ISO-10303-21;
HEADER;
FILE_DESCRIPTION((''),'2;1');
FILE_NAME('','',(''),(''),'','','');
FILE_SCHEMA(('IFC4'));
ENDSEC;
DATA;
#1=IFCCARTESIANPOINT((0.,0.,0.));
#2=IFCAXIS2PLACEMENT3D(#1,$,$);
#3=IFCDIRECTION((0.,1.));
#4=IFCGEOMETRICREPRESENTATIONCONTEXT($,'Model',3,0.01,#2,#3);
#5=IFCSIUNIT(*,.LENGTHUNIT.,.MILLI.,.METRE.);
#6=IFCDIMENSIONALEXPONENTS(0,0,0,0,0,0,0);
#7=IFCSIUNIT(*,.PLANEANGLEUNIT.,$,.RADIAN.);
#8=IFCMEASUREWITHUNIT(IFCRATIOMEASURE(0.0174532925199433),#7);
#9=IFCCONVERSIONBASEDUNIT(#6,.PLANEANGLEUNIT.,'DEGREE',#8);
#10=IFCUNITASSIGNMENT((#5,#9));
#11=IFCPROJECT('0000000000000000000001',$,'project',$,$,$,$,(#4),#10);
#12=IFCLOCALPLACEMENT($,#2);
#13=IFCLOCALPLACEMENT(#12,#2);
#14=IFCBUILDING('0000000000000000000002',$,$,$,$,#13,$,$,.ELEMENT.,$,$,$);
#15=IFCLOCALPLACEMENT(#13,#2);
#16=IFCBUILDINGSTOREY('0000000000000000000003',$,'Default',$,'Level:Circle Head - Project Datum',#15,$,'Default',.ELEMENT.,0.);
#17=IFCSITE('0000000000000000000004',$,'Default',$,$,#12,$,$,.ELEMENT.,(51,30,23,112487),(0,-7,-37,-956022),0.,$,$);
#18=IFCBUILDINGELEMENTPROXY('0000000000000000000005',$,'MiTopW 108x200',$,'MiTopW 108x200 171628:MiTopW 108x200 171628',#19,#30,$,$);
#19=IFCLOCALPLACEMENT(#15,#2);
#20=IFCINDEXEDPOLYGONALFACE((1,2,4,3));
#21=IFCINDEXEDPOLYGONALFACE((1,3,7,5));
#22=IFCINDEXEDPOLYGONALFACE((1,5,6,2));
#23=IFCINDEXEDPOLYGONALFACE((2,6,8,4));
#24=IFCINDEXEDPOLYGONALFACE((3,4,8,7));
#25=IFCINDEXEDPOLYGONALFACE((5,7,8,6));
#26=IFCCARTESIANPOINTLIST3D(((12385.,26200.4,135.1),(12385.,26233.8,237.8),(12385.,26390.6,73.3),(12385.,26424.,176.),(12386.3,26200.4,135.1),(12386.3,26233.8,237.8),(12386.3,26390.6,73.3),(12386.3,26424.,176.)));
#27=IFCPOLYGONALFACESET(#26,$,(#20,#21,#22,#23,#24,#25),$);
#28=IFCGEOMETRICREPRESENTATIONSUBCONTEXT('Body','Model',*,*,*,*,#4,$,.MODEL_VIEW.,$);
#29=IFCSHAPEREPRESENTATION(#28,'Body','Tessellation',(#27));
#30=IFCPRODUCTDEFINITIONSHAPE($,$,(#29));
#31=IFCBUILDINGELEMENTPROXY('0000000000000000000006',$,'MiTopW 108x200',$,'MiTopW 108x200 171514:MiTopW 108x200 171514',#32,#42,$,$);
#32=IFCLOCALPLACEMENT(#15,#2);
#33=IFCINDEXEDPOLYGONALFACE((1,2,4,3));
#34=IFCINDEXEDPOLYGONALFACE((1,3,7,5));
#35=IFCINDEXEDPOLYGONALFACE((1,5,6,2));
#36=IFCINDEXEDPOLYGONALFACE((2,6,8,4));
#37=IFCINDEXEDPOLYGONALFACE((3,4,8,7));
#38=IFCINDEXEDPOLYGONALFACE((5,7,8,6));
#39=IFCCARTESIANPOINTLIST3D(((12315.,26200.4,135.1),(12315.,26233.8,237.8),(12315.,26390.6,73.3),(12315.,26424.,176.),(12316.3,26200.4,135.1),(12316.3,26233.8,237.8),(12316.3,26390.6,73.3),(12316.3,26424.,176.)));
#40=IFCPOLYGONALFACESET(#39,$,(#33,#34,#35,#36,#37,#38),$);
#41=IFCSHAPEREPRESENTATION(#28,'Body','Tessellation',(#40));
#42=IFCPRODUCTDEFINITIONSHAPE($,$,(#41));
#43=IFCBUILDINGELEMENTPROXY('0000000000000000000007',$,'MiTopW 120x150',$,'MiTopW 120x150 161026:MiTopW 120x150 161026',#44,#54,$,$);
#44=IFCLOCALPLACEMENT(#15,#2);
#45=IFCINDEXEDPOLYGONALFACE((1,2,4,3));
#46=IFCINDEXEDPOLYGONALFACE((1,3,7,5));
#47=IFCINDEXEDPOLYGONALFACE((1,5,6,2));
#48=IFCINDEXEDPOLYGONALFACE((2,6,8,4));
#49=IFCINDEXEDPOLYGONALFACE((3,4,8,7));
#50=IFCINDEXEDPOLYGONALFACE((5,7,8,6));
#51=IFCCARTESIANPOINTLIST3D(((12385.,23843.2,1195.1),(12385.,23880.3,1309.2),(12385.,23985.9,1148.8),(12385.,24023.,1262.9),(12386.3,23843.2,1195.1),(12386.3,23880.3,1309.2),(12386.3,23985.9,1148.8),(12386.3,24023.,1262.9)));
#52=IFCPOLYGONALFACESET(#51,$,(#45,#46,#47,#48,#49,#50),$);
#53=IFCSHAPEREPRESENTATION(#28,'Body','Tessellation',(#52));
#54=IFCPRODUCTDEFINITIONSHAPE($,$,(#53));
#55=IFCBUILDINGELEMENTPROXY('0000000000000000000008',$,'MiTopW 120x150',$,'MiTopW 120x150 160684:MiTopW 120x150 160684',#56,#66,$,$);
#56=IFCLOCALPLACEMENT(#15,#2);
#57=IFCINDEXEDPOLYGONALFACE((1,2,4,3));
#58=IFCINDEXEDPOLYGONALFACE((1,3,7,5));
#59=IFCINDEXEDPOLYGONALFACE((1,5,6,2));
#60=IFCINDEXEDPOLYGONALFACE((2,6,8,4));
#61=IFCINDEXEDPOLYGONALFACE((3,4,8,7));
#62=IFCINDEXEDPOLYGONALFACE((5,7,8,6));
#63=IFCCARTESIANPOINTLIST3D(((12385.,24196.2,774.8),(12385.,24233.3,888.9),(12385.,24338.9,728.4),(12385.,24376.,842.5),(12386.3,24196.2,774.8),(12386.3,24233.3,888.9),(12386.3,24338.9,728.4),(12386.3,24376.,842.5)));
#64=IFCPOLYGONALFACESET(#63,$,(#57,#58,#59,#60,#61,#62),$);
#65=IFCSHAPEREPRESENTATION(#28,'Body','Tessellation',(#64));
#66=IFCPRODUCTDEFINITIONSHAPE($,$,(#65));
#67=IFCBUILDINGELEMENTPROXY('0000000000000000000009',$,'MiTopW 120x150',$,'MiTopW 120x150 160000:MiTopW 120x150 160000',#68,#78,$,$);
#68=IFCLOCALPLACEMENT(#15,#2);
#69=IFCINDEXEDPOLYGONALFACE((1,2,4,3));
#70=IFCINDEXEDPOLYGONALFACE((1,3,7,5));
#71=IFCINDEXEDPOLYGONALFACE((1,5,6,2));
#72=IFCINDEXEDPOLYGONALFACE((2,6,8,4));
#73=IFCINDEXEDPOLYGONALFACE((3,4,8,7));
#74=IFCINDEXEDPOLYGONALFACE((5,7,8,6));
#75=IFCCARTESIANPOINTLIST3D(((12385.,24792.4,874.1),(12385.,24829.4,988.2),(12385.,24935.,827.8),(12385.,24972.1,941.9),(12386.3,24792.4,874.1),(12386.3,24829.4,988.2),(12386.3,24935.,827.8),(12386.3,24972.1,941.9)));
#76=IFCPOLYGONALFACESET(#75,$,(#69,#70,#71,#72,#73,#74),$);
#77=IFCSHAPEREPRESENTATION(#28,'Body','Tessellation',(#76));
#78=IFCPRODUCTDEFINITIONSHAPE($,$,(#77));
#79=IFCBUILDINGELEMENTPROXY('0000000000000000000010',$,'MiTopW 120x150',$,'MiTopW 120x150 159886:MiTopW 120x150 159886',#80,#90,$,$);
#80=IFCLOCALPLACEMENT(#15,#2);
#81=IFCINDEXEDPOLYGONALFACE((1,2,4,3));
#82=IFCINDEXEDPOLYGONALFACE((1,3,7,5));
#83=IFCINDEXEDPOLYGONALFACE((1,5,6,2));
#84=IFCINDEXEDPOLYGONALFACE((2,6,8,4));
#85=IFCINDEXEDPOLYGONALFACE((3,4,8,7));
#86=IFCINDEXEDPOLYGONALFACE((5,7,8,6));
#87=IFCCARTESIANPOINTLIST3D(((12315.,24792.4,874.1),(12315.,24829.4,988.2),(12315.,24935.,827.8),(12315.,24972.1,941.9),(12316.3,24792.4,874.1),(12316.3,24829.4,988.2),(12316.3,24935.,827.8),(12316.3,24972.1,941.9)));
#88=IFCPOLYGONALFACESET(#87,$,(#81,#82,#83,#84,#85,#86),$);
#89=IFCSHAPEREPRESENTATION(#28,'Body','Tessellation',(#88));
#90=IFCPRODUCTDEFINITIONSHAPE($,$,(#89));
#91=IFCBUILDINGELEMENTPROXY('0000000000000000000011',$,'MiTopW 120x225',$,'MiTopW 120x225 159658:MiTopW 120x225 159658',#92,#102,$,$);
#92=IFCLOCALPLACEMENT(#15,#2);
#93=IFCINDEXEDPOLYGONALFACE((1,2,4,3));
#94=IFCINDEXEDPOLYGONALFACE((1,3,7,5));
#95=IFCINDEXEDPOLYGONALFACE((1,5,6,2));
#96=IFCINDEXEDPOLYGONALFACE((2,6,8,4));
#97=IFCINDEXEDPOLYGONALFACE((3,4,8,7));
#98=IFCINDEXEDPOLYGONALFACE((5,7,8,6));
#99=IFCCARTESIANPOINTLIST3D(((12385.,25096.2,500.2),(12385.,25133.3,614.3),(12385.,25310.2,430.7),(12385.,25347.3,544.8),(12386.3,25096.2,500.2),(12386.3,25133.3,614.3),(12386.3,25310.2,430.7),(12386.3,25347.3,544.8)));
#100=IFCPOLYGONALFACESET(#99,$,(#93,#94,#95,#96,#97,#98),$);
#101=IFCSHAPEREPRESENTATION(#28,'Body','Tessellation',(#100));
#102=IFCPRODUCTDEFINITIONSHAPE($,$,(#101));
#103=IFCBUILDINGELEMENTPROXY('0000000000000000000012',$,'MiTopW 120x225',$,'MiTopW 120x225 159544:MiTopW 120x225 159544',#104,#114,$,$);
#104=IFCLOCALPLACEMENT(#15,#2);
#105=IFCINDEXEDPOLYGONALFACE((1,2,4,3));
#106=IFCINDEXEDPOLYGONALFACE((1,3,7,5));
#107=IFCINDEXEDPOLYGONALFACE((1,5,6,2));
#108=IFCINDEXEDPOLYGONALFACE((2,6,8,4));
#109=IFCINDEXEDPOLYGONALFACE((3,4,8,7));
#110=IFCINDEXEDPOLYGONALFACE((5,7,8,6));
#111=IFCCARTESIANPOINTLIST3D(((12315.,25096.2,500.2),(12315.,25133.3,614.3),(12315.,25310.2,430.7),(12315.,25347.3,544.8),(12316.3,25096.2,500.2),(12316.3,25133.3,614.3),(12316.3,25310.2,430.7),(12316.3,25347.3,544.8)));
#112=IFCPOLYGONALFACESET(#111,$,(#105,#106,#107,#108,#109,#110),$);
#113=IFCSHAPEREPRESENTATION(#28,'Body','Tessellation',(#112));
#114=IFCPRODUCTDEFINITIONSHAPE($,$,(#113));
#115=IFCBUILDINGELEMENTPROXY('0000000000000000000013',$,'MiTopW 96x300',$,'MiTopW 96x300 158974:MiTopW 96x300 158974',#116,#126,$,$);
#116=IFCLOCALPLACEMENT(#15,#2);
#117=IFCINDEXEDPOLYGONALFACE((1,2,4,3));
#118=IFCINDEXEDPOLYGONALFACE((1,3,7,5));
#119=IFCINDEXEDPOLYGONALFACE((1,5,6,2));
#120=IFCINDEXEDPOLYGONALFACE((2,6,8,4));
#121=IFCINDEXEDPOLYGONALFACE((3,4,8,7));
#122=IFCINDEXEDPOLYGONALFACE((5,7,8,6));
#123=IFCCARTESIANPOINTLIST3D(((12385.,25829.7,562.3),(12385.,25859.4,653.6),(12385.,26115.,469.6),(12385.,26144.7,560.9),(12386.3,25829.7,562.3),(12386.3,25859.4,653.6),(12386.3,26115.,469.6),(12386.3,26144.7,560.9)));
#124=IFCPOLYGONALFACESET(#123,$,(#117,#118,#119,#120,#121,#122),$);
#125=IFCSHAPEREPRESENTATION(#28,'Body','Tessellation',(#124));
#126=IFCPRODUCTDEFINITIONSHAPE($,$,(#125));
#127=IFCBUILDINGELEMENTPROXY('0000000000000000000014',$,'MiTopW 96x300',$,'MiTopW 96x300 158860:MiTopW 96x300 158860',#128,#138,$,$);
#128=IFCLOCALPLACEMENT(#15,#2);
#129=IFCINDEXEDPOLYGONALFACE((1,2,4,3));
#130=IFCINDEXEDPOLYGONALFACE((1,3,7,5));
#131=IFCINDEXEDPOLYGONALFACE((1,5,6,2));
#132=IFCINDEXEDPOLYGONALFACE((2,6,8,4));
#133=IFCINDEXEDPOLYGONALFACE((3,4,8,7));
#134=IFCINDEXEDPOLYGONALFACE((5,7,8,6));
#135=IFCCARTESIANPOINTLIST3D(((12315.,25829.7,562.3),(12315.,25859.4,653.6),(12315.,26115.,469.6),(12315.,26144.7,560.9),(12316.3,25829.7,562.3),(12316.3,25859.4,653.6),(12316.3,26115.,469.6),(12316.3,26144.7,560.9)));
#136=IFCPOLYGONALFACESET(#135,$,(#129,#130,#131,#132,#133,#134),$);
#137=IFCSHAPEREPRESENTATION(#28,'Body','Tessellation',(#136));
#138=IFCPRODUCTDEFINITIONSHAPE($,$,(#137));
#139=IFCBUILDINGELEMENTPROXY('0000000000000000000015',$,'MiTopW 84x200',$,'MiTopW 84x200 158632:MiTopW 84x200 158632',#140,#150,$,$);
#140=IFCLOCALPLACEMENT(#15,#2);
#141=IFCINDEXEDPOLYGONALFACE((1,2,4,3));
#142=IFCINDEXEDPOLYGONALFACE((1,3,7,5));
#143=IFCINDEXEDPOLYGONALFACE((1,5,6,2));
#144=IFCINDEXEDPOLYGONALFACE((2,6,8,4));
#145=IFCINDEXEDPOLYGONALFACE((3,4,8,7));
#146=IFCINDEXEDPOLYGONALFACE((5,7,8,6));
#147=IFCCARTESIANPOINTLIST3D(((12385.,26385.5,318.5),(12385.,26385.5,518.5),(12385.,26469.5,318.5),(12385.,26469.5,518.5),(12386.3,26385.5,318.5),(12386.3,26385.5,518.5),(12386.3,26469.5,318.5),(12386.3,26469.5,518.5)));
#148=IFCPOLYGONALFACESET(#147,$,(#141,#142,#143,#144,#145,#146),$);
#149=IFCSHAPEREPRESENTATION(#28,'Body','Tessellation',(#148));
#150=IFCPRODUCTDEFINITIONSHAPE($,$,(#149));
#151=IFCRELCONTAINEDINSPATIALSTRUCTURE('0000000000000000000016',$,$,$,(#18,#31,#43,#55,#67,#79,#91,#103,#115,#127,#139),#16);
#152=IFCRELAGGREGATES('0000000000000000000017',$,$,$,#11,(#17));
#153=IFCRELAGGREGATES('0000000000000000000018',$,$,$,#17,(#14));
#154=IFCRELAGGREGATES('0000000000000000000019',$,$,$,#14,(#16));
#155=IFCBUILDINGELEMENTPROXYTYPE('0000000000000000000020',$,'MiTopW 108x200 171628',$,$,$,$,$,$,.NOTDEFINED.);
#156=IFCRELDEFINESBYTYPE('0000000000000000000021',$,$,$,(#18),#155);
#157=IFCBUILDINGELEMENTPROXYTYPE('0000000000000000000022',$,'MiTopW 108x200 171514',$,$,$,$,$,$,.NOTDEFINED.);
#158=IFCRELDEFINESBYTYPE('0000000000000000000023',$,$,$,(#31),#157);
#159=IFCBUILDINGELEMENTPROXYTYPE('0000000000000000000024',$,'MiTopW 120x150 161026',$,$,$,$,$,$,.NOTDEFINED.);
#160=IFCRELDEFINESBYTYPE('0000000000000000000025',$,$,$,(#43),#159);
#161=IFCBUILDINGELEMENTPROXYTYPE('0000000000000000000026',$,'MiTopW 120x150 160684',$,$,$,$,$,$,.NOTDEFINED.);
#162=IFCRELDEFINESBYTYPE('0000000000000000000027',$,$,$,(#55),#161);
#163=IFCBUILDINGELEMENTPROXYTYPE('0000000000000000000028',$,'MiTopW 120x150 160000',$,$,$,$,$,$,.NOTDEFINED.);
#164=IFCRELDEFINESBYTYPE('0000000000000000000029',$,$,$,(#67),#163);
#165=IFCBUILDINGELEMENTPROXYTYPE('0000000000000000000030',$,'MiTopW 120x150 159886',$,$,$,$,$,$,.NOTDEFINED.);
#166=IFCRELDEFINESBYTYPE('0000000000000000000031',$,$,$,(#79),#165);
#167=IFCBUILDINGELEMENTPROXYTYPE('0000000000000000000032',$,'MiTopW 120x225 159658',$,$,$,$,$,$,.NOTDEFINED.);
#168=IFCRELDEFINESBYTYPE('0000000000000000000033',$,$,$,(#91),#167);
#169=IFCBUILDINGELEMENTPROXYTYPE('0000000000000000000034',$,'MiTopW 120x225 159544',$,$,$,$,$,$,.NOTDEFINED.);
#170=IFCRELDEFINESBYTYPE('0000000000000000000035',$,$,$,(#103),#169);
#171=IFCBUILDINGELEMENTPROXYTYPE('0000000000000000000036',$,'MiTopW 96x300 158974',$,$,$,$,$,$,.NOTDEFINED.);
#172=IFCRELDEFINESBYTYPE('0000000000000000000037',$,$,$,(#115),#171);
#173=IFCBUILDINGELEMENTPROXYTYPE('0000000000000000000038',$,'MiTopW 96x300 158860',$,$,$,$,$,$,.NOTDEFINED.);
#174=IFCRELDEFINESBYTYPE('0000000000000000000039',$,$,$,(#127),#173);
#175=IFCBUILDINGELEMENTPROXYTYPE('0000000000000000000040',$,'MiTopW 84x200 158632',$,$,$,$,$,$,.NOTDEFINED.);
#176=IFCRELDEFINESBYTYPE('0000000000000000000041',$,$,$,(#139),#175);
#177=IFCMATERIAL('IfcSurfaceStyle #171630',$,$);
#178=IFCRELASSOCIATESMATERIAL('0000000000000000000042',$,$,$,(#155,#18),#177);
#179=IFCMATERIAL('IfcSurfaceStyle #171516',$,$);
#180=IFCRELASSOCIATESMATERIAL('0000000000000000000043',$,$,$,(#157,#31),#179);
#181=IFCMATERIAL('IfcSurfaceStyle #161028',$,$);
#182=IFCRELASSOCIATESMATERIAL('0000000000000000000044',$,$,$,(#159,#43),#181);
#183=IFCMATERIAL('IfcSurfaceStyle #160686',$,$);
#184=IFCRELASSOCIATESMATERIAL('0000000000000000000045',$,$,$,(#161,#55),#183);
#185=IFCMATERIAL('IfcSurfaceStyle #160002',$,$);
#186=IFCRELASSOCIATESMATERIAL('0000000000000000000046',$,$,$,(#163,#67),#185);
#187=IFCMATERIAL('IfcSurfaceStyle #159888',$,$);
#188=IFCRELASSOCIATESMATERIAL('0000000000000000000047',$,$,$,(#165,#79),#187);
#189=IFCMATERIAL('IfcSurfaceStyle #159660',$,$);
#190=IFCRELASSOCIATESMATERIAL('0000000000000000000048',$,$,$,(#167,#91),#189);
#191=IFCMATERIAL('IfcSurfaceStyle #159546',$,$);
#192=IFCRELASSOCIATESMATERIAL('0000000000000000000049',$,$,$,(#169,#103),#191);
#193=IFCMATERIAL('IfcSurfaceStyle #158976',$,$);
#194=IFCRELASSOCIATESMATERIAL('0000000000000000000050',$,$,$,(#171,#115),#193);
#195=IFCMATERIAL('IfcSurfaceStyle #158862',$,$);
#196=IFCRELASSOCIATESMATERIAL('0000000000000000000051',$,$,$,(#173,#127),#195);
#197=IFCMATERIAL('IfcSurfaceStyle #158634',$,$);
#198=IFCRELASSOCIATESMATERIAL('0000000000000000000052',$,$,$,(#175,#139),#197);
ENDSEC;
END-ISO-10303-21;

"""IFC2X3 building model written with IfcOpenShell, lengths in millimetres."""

from ifc_helpers import new_model, entity, si_unit, converted_unit, direction, frame, frame_2d, origin, place, context, subcontext, project, spatial, polyline, rectangle, outline, extrude, source, transform, mapped, material, type_object, type_shapes, element, save


model = new_model("IFC2X3")

# Units and contexts
model_context = context("Model", 3, precision=0.01, world=origin(), true_north=direction((0.0, 1.0)))
body_context = subcontext(model_context, "Body", "Model", "MODEL_VIEW")
ifc_project = project(units=[si_unit("LENGTHUNIT", "METRE", prefix="MILLI"), converted_unit("PLANEANGLEUNIT", "DEGREE", entity("IfcRatioMeasure", 0.0174532925199433), si_unit("PLANEANGLEUNIT", "RADIAN"), dimensions=[0, 0, 0, 0, 0, 0, 0])], contexts=[model_context])

# Site, building, storey
site_placement = place(None, origin())
site = spatial("IfcSite", under=ifc_project, at=site_placement, Name="Default", CompositionType="ELEMENT", RefLatitude=(51, 30, 23, 112487), RefLongitude=(0, -7, -37, -956022), RefElevation=0.0)
building_placement = place(site_placement, origin())
building = spatial("IfcBuilding", under=site, at=building_placement, CompositionType="ELEMENT")
storey_placement = place(building_placement, origin())
storey = spatial("IfcBuildingStorey", under=building, at=storey_placement, Name="Default", ObjectType="Level:Circle Head - Project Datum", LongName="Default", CompositionType="ELEMENT", Elevation=0.0)

# Building element proxies
ifc_material_1 = material(Name="IfcSurfaceStyle #171630")
building_element_proxy_type_1 = type_object("IfcBuildingElementProxyType", Name="MiTopW 108x200 171628", PredefinedType="NOTDEFINED", material=ifc_material_1)
shared_shape_1 = source(origin(), body_context, "Body", "SweptSolid", [
    extrude(outline(polyline([(-100.0, -54.0), (100.0, -54.0), (100.0, 54.0), (-100.0, 54.0), (-100.0, -54.0)])), frame((100.0, 54.0, 0.0), z_axis=(0.0, 0.0, 1.0), x_axis=(-1.0, 0.0, 0.0)), (0.0, 0.0, 1.0), 1.3),
])
type_shapes(building_element_proxy_type_1, [shared_shape_1])
proxy_1_placement = place(building_placement, frame((12386.3, 26390.6, 73.3), z_axis=(-1.0, 0.0, 0.0), x_axis=(0.0, -0.951057, 0.309017)))
element("IfcBuildingElementProxy", 1, at=proxy_1_placement, inside=storey, type_object=building_element_proxy_type_1, material=ifc_material_1, Name="MiTopW 108x200", ObjectType="MiTopW 108x200 171628:MiTopW 108x200 171628", context=body_context, shape_type="MappedRepresentation", body=[
    mapped(shared_shape_1, transform((0.0, 0.0, 0.0), scale=1.0)),
])
ifc_material_2 = material(Name="IfcSurfaceStyle #171516")
building_element_proxy_type_2 = type_object("IfcBuildingElementProxyType", Name="MiTopW 108x200 171514", PredefinedType="NOTDEFINED", material=ifc_material_2)
shared_shape_2 = source(origin(), body_context, "Body", "SweptSolid", [
    extrude(outline(polyline([(-100.0, -54.0), (100.0, -54.0), (100.0, 54.0), (-100.0, 54.0), (-100.0, -54.0)])), frame((100.0, 54.0, 0.0), z_axis=(0.0, 0.0, 1.0), x_axis=(-1.0, 0.0, 0.0)), (0.0, 0.0, 1.0), 1.3),
])
type_shapes(building_element_proxy_type_2, [shared_shape_2])
proxy_2_placement = place(building_placement, frame((12316.3, 26390.6, 73.3), z_axis=(-1.0, 0.0, 0.0), x_axis=(0.0, -0.951057, 0.309017)))
element("IfcBuildingElementProxy", 2, at=proxy_2_placement, inside=storey, type_object=building_element_proxy_type_2, material=ifc_material_2, Name="MiTopW 108x200", ObjectType="MiTopW 108x200 171514:MiTopW 108x200 171514", context=body_context, shape_type="MappedRepresentation", body=[
    mapped(shared_shape_2, transform((0.0, 0.0, 0.0), scale=1.0)),
])
ifc_material_3 = material(Name="IfcSurfaceStyle #161028")
building_element_proxy_type_3 = type_object("IfcBuildingElementProxyType", Name="MiTopW 120x150 161026", PredefinedType="NOTDEFINED", material=ifc_material_3)
shared_shape_3 = source(origin(), body_context, "Body", "SweptSolid", [
    extrude(outline(polyline([(-75.0, -60.0), (75.0, -60.0), (75.0, 60.0), (-75.0, 60.0), (-75.0, -60.0)])), frame((75.0, 60.0, 0.0), z_axis=(0.0, 0.0, 1.0), x_axis=(-1.0, 0.0, 0.0)), (0.0, 0.0, 1.0), 1.3),
])
type_shapes(building_element_proxy_type_3, [shared_shape_3])
proxy_3_placement = place(building_placement, frame((12386.3, 23985.9, 1148.8), z_axis=(-1.0, 0.0, 0.0), x_axis=(0.0, -0.951057, 0.309017)))
element("IfcBuildingElementProxy", 3, at=proxy_3_placement, inside=storey, type_object=building_element_proxy_type_3, material=ifc_material_3, Name="MiTopW 120x150", ObjectType="MiTopW 120x150 161026:MiTopW 120x150 161026", context=body_context, shape_type="MappedRepresentation", body=[
    mapped(shared_shape_3, transform((0.0, 0.0, 0.0), scale=1.0)),
])
ifc_material_4 = material(Name="IfcSurfaceStyle #160686")
building_element_proxy_type_4 = type_object("IfcBuildingElementProxyType", Name="MiTopW 120x150 160684", PredefinedType="NOTDEFINED", material=ifc_material_4)
shared_shape_4 = source(origin(), body_context, "Body", "SweptSolid", [
    extrude(outline(polyline([(-75.0, -60.0), (75.0, -60.0), (75.0, 60.0), (-75.0, 60.0), (-75.0, -60.0)])), frame((75.0, 60.0, 0.0), z_axis=(0.0, 0.0, 1.0), x_axis=(-1.0, 0.0, 0.0)), (0.0, 0.0, 1.0), 1.3),
])
type_shapes(building_element_proxy_type_4, [shared_shape_4])
proxy_4_placement = place(building_placement, frame((12386.3, 24338.9, 728.4), z_axis=(-1.0, 0.0, 0.0), x_axis=(0.0, -0.951057, 0.309017)))
element("IfcBuildingElementProxy", 4, at=proxy_4_placement, inside=storey, type_object=building_element_proxy_type_4, material=ifc_material_4, Name="MiTopW 120x150", ObjectType="MiTopW 120x150 160684:MiTopW 120x150 160684", context=body_context, shape_type="MappedRepresentation", body=[
    mapped(shared_shape_4, transform((0.0, 0.0, 0.0), scale=1.0)),
])
ifc_material_5 = material(Name="IfcSurfaceStyle #160002")
building_element_proxy_type_5 = type_object("IfcBuildingElementProxyType", Name="MiTopW 120x150 160000", PredefinedType="NOTDEFINED", material=ifc_material_5)
shared_shape_5 = source(origin(), body_context, "Body", "SweptSolid", [
    extrude(outline(polyline([(-75.0, -60.0), (75.0, -60.0), (75.0, 60.0), (-75.0, 60.0), (-75.0, -60.0)])), frame((75.0, 60.0, 0.0), z_axis=(0.0, 0.0, 1.0), x_axis=(-1.0, 0.0, 0.0)), (0.0, 0.0, 1.0), 1.3),
])
type_shapes(building_element_proxy_type_5, [shared_shape_5])
proxy_5_placement = place(building_placement, frame((12386.3, 24935.0, 827.8), z_axis=(-1.0, 0.0, 0.0), x_axis=(0.0, -0.951057, 0.309017)))
element("IfcBuildingElementProxy", 5, at=proxy_5_placement, inside=storey, type_object=building_element_proxy_type_5, material=ifc_material_5, Name="MiTopW 120x150", ObjectType="MiTopW 120x150 160000:MiTopW 120x150 160000", context=body_context, shape_type="MappedRepresentation", body=[
    mapped(shared_shape_5, transform((0.0, 0.0, 0.0), scale=1.0)),
])
ifc_material_6 = material(Name="IfcSurfaceStyle #159888")
building_element_proxy_type_6 = type_object("IfcBuildingElementProxyType", Name="MiTopW 120x150 159886", PredefinedType="NOTDEFINED", material=ifc_material_6)
shared_shape_6 = source(origin(), body_context, "Body", "SweptSolid", [
    extrude(outline(polyline([(-75.0, -60.0), (75.0, -60.0), (75.0, 60.0), (-75.0, 60.0), (-75.0, -60.0)])), frame((75.0, 60.0, 0.0), z_axis=(0.0, 0.0, 1.0), x_axis=(-1.0, 0.0, 0.0)), (0.0, 0.0, 1.0), 1.3),
])
type_shapes(building_element_proxy_type_6, [shared_shape_6])
proxy_6_placement = place(building_placement, frame((12316.3, 24935.0, 827.8), z_axis=(-1.0, 0.0, 0.0), x_axis=(0.0, -0.951057, 0.309017)))
element("IfcBuildingElementProxy", 6, at=proxy_6_placement, inside=storey, type_object=building_element_proxy_type_6, material=ifc_material_6, Name="MiTopW 120x150", ObjectType="MiTopW 120x150 159886:MiTopW 120x150 159886", context=body_context, shape_type="MappedRepresentation", body=[
    mapped(shared_shape_6, transform((0.0, 0.0, 0.0), scale=1.0)),
])
ifc_material_7 = material(Name="IfcSurfaceStyle #159660")
building_element_proxy_type_7 = type_object("IfcBuildingElementProxyType", Name="MiTopW 120x225 159658", PredefinedType="NOTDEFINED", material=ifc_material_7)
shared_shape_7 = source(origin(), body_context, "Body", "SweptSolid", [
    extrude(outline(polyline([(-112.5, -60.0), (112.5, -60.0), (112.5, 60.0), (-112.5, 60.0), (-112.5, -60.0)])), frame((112.5, 60.0, 0.0), z_axis=(0.0, 0.0, 1.0), x_axis=(-1.0, 0.0, 0.0)), (0.0, 0.0, 1.0), 1.3),
])
type_shapes(building_element_proxy_type_7, [shared_shape_7])
proxy_7_placement = place(building_placement, frame((12386.3, 25310.2, 430.7), z_axis=(-1.0, 0.0, 0.0), x_axis=(0.0, -0.951057, 0.309017)))
element("IfcBuildingElementProxy", 7, at=proxy_7_placement, inside=storey, type_object=building_element_proxy_type_7, material=ifc_material_7, Name="MiTopW 120x225", ObjectType="MiTopW 120x225 159658:MiTopW 120x225 159658", context=body_context, shape_type="MappedRepresentation", body=[
    mapped(shared_shape_7, transform((0.0, 0.0, 0.0), scale=1.0)),
])
ifc_material_8 = material(Name="IfcSurfaceStyle #159546")
building_element_proxy_type_8 = type_object("IfcBuildingElementProxyType", Name="MiTopW 120x225 159544", PredefinedType="NOTDEFINED", material=ifc_material_8)
shared_shape_8 = source(origin(), body_context, "Body", "SweptSolid", [
    extrude(outline(polyline([(-112.5, -60.0), (112.5, -60.0), (112.5, 60.0), (-112.5, 60.0), (-112.5, -60.0)])), frame((112.5, 60.0, 0.0), z_axis=(0.0, 0.0, 1.0), x_axis=(-1.0, 0.0, 0.0)), (0.0, 0.0, 1.0), 1.3),
])
type_shapes(building_element_proxy_type_8, [shared_shape_8])
proxy_8_placement = place(building_placement, frame((12316.3, 25310.2, 430.7), z_axis=(-1.0, 0.0, 0.0), x_axis=(0.0, -0.951057, 0.309017)))
element("IfcBuildingElementProxy", 8, at=proxy_8_placement, inside=storey, type_object=building_element_proxy_type_8, material=ifc_material_8, Name="MiTopW 120x225", ObjectType="MiTopW 120x225 159544:MiTopW 120x225 159544", context=body_context, shape_type="MappedRepresentation", body=[
    mapped(shared_shape_8, transform((0.0, 0.0, 0.0), scale=1.0)),
])
ifc_material_9 = material(Name="IfcSurfaceStyle #158976")
building_element_proxy_type_9 = type_object("IfcBuildingElementProxyType", Name="MiTopW 96x300 158974", PredefinedType="NOTDEFINED", material=ifc_material_9)
shared_shape_9 = source(origin(), body_context, "Body", "SweptSolid", [
    extrude(outline(polyline([(-150.0, -48.0), (150.0, -48.0), (150.0, 48.0), (-150.0, 48.0), (-150.0, -48.0)])), frame((150.0, 48.0, 0.0), z_axis=(0.0, 0.0, 1.0), x_axis=(-1.0, 0.0, 0.0)), (0.0, 0.0, 1.0), 1.3),
])
type_shapes(building_element_proxy_type_9, [shared_shape_9])
proxy_9_placement = place(building_placement, frame((12386.3, 26115.0, 469.6), z_axis=(-1.0, 0.0, 0.0), x_axis=(0.0, -0.951057, 0.309017)))
element("IfcBuildingElementProxy", 9, at=proxy_9_placement, inside=storey, type_object=building_element_proxy_type_9, material=ifc_material_9, Name="MiTopW 96x300", ObjectType="MiTopW 96x300 158974:MiTopW 96x300 158974", context=body_context, shape_type="MappedRepresentation", body=[
    mapped(shared_shape_9, transform((0.0, 0.0, 0.0), scale=1.0)),
])
ifc_material_10 = material(Name="IfcSurfaceStyle #158862")
building_element_proxy_type_10 = type_object("IfcBuildingElementProxyType", Name="MiTopW 96x300 158860", PredefinedType="NOTDEFINED", material=ifc_material_10)
shared_shape_10 = source(origin(), body_context, "Body", "SweptSolid", [
    extrude(outline(polyline([(-150.0, -48.0), (150.0, -48.0), (150.0, 48.0), (-150.0, 48.0), (-150.0, -48.0)])), frame((150.0, 48.0, 0.0), z_axis=(0.0, 0.0, 1.0), x_axis=(-1.0, 0.0, 0.0)), (0.0, 0.0, 1.0), 1.3),
])
type_shapes(building_element_proxy_type_10, [shared_shape_10])
proxy_10_placement = place(building_placement, frame((12316.3, 26115.0, 469.6), z_axis=(-1.0, 0.0, 0.0), x_axis=(0.0, -0.951057, 0.309017)))
element("IfcBuildingElementProxy", 10, at=proxy_10_placement, inside=storey, type_object=building_element_proxy_type_10, material=ifc_material_10, Name="MiTopW 96x300", ObjectType="MiTopW 96x300 158860:MiTopW 96x300 158860", context=body_context, shape_type="MappedRepresentation", body=[
    mapped(shared_shape_10, transform((0.0, 0.0, 0.0), scale=1.0)),
])
ifc_material_11 = material(Name="IfcSurfaceStyle #158634")
building_element_proxy_type_11 = type_object("IfcBuildingElementProxyType", Name="MiTopW 84x200 158632", PredefinedType="NOTDEFINED", material=ifc_material_11)
shared_shape_11 = source(origin(), body_context, "Body", "SweptSolid", [
    extrude(rectangle(XDim=200.0, YDim=84.0, at=frame_2d((0.0, 0.0), x_axis=(1.0, 0.0))), frame((100.0, 42.0, 0.0), z_axis=(0.0, 0.0, 1.0), x_axis=(-1.0, 0.0, 0.0)), (0.0, 0.0, 1.0), 1.3),
])
type_shapes(building_element_proxy_type_11, [shared_shape_11])
proxy_11_placement = place(building_placement, frame((12386.3, 26469.5, 518.5), z_axis=(-1.0, 0.0, 0.0), x_axis=(0.0, 0.0, -1.0)))
element("IfcBuildingElementProxy", 11, at=proxy_11_placement, inside=storey, type_object=building_element_proxy_type_11, material=ifc_material_11, Name="MiTopW 84x200", ObjectType="MiTopW 84x200 158632:MiTopW 84x200 158632", context=body_context, shape_type="MappedRepresentation", body=[
    mapped(shared_shape_11, transform((0.0, 0.0, 0.0), scale=1.0)),
])

save(model, "model.ifc")
